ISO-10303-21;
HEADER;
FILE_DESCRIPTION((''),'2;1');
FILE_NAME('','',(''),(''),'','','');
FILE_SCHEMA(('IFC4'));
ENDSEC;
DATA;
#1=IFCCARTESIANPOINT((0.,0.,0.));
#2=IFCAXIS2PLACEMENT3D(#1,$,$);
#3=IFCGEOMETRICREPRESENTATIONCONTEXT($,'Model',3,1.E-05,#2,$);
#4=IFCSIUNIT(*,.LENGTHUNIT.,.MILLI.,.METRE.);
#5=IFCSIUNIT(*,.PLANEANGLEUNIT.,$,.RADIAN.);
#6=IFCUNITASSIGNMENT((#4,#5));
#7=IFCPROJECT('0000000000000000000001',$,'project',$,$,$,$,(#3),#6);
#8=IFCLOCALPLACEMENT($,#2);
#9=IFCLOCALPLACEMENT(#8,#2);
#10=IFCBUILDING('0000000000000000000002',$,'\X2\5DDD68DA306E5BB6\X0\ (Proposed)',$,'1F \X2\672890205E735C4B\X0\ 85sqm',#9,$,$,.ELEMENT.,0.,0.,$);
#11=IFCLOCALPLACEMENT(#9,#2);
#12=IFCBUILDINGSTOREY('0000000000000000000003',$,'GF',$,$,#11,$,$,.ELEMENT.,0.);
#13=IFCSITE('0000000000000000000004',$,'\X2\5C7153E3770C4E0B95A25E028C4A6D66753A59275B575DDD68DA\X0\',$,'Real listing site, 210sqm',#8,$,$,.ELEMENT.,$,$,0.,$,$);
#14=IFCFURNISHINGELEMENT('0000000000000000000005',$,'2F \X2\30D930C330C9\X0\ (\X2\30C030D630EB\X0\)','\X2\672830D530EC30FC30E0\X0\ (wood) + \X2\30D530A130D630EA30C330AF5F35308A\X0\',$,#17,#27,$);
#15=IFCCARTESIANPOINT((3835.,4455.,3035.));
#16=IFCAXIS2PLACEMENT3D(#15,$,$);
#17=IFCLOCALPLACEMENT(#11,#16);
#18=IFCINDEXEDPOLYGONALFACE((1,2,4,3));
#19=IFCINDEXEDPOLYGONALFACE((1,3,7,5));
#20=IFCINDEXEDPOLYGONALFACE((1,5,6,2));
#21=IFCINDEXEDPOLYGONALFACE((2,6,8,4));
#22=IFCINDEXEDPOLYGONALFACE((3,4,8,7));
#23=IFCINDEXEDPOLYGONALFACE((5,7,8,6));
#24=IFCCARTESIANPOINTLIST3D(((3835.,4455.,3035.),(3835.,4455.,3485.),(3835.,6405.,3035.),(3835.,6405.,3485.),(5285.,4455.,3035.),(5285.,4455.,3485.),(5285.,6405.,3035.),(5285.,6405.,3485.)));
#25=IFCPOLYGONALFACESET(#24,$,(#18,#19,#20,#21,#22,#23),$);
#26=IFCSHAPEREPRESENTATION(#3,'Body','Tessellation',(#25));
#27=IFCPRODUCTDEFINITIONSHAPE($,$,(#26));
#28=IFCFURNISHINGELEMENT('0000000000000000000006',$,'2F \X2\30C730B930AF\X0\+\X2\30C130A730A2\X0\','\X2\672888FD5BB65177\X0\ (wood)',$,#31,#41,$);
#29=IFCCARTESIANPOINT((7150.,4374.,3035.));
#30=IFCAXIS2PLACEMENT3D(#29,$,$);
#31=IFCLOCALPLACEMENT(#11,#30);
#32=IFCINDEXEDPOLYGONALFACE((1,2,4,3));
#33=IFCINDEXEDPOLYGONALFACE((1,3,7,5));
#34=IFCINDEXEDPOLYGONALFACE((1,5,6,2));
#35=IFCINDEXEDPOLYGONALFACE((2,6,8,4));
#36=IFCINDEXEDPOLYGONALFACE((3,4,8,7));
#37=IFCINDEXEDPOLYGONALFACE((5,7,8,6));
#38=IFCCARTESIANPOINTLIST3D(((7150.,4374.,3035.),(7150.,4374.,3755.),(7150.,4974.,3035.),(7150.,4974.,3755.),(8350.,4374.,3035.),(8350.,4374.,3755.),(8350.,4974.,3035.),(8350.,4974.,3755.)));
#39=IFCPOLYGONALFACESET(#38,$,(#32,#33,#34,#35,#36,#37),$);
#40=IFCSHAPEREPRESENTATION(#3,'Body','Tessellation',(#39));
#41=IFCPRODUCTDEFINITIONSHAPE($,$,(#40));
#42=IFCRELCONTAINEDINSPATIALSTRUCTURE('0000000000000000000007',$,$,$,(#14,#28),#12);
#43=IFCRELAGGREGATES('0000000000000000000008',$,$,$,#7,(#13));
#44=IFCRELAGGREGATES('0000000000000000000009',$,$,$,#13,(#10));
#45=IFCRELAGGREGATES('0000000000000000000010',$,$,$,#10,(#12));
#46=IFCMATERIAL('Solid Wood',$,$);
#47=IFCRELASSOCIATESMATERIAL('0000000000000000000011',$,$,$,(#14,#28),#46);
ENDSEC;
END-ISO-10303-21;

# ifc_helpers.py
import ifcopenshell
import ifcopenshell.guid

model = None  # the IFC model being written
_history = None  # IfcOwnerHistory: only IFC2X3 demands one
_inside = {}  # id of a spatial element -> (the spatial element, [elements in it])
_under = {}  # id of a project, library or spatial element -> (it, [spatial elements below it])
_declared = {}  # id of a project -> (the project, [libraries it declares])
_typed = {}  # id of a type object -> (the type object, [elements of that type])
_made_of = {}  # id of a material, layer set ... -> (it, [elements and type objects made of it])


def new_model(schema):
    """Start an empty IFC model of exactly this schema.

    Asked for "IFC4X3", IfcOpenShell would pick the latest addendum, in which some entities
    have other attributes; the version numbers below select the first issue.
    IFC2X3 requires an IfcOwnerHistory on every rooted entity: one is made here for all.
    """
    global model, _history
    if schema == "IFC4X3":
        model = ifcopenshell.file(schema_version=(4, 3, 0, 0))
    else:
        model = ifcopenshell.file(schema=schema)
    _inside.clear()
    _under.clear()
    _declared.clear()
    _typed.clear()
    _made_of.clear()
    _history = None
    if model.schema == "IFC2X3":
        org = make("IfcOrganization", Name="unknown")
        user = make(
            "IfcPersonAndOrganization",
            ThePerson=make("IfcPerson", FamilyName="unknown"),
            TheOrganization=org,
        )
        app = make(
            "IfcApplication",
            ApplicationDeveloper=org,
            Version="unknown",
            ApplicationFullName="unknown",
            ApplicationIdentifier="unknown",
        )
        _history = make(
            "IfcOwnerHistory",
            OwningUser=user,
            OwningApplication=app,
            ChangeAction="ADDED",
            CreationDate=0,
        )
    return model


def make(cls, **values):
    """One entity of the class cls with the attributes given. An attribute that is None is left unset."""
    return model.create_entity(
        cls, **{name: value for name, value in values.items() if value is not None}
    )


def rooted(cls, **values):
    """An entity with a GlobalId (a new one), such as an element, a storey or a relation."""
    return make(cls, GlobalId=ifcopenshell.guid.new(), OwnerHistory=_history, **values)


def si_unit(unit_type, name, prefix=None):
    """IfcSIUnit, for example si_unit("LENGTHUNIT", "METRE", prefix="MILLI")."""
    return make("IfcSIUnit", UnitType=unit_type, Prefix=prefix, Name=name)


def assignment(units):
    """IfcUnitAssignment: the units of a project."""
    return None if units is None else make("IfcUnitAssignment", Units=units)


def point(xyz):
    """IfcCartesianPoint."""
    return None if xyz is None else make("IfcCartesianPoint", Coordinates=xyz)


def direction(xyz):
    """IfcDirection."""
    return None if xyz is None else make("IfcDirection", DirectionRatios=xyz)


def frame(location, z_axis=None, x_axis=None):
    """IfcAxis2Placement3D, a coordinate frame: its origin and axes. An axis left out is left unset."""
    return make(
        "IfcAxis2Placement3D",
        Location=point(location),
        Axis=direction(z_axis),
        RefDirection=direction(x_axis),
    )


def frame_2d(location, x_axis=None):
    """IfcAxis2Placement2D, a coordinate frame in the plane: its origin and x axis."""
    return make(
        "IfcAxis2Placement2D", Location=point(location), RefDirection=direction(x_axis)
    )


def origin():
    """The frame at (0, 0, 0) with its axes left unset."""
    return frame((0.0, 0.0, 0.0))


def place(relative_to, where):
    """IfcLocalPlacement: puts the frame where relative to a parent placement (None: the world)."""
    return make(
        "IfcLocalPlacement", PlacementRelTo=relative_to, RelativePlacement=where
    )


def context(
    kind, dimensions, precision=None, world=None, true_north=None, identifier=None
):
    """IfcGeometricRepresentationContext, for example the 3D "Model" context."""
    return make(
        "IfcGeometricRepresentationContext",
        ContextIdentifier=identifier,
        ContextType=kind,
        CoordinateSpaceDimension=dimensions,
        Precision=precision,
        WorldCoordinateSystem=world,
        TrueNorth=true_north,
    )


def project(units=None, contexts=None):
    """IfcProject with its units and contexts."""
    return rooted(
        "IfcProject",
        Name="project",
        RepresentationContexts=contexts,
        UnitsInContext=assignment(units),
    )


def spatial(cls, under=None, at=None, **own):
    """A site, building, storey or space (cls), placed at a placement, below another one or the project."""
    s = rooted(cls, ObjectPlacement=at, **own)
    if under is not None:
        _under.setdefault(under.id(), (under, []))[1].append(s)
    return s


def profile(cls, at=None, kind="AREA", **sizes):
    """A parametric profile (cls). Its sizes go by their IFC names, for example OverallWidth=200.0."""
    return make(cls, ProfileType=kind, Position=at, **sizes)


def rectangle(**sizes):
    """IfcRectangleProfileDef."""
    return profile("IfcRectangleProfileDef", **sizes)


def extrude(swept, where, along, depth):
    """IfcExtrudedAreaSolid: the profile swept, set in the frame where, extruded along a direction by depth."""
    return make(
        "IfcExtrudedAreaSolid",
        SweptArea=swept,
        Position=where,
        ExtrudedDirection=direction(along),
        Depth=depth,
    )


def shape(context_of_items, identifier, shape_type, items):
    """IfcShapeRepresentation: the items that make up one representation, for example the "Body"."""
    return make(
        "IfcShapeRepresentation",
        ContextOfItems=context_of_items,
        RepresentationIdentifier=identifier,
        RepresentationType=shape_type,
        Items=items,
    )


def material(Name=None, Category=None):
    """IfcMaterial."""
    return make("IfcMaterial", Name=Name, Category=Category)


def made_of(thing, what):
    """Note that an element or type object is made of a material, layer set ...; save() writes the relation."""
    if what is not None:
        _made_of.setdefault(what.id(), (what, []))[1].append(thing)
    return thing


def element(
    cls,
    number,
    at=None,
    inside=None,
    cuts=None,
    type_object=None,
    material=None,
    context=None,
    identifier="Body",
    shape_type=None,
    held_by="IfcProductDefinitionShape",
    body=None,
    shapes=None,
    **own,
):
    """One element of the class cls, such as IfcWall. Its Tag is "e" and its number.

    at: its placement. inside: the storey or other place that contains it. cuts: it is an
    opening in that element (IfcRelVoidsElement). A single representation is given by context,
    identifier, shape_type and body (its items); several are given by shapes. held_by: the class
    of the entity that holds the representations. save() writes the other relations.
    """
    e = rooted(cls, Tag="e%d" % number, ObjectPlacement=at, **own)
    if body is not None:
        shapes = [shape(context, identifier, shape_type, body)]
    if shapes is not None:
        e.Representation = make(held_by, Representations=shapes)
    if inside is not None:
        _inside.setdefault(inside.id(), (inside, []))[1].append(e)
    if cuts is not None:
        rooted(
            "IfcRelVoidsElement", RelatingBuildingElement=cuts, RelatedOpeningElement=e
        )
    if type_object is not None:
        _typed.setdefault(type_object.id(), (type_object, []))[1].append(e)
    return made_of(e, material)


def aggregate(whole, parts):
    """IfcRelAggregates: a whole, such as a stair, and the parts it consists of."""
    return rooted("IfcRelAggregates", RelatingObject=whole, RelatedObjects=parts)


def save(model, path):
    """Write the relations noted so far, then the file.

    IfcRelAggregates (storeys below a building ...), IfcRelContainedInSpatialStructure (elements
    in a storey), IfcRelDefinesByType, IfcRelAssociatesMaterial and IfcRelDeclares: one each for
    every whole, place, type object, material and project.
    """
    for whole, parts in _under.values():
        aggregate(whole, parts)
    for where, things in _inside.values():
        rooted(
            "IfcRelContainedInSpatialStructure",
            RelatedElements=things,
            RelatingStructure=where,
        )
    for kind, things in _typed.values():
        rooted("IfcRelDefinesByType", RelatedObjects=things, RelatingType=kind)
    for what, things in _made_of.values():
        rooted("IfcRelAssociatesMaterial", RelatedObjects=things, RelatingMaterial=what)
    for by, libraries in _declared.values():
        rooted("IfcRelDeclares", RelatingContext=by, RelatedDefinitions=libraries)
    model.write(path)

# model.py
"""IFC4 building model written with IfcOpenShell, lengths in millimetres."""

from ifc_helpers import new_model, si_unit, frame, frame_2d, origin, place, context, project, spatial, rectangle, extrude, material, element, save


model = new_model("IFC4")

# Units and contexts
model_context = context("Model", 3, precision=1e-05, world=origin())
ifc_project = project(units=[si_unit("LENGTHUNIT", "METRE", prefix="MILLI"), si_unit("PLANEANGLEUNIT", "RADIAN")], contexts=[model_context])

# Site, building, storey
site_placement = place(None, origin())
site = spatial("IfcSite", under=ifc_project, at=site_placement, Name="山口県下関市豊浦町大字川棚", ObjectType="Real listing site, 210sqm", CompositionType="ELEMENT", RefElevation=0.0)
building_placement = place(site_placement, origin())
building = spatial("IfcBuilding", under=site, at=building_placement, Name="川棚の家 (Proposed)", ObjectType="1F 木造平屋 85sqm", CompositionType="ELEMENT", ElevationOfRefHeight=0.0, ElevationOfTerrain=0.0)
storey_placement = place(building_placement, origin())
storey = spatial("IfcBuildingStorey", under=building, at=storey_placement, Name="GF", CompositionType="ELEMENT", Elevation=0.0)

# Shared definitions
ifc_material_1 = material(Name="Solid Wood")

# Furnishing elements
furnishing_1_placement = place(storey_placement, frame((3835.0, 4455.0, 3035.0)))
element("IfcFurnishingElement", 1, at=furnishing_1_placement, inside=storey, material=ifc_material_1, Name="2F ベッド (ダブル)", Description="木フレーム (wood) + ファブリック張り", context=model_context, shape_type="SweptSolid", body=[
    extrude(rectangle(XDim=1450.0, YDim=1950.0, at=frame_2d((725.0, 975.0))), frame((3835.0, 4455.0, 3035.0)), (0.0, 0.0, 1.0), 450.0),
])
furnishing_2_placement = place(storey_placement, frame((7150.0, 4374.0, 3035.0)))
element("IfcFurnishingElement", 2, at=furnishing_2_placement, inside=storey, material=ifc_material_1, Name="2F デスク+チェア", Description="木製家具 (wood)", context=model_context, shape_type="SweptSolid", body=[
    extrude(rectangle(XDim=1200.0, YDim=600.0, at=frame_2d((600.0, 300.0))), frame((7150.0, 4374.0, 3035.0)), (0.0, 0.0, 1.0), 720.0),
])

save(model, "model.ifc")
